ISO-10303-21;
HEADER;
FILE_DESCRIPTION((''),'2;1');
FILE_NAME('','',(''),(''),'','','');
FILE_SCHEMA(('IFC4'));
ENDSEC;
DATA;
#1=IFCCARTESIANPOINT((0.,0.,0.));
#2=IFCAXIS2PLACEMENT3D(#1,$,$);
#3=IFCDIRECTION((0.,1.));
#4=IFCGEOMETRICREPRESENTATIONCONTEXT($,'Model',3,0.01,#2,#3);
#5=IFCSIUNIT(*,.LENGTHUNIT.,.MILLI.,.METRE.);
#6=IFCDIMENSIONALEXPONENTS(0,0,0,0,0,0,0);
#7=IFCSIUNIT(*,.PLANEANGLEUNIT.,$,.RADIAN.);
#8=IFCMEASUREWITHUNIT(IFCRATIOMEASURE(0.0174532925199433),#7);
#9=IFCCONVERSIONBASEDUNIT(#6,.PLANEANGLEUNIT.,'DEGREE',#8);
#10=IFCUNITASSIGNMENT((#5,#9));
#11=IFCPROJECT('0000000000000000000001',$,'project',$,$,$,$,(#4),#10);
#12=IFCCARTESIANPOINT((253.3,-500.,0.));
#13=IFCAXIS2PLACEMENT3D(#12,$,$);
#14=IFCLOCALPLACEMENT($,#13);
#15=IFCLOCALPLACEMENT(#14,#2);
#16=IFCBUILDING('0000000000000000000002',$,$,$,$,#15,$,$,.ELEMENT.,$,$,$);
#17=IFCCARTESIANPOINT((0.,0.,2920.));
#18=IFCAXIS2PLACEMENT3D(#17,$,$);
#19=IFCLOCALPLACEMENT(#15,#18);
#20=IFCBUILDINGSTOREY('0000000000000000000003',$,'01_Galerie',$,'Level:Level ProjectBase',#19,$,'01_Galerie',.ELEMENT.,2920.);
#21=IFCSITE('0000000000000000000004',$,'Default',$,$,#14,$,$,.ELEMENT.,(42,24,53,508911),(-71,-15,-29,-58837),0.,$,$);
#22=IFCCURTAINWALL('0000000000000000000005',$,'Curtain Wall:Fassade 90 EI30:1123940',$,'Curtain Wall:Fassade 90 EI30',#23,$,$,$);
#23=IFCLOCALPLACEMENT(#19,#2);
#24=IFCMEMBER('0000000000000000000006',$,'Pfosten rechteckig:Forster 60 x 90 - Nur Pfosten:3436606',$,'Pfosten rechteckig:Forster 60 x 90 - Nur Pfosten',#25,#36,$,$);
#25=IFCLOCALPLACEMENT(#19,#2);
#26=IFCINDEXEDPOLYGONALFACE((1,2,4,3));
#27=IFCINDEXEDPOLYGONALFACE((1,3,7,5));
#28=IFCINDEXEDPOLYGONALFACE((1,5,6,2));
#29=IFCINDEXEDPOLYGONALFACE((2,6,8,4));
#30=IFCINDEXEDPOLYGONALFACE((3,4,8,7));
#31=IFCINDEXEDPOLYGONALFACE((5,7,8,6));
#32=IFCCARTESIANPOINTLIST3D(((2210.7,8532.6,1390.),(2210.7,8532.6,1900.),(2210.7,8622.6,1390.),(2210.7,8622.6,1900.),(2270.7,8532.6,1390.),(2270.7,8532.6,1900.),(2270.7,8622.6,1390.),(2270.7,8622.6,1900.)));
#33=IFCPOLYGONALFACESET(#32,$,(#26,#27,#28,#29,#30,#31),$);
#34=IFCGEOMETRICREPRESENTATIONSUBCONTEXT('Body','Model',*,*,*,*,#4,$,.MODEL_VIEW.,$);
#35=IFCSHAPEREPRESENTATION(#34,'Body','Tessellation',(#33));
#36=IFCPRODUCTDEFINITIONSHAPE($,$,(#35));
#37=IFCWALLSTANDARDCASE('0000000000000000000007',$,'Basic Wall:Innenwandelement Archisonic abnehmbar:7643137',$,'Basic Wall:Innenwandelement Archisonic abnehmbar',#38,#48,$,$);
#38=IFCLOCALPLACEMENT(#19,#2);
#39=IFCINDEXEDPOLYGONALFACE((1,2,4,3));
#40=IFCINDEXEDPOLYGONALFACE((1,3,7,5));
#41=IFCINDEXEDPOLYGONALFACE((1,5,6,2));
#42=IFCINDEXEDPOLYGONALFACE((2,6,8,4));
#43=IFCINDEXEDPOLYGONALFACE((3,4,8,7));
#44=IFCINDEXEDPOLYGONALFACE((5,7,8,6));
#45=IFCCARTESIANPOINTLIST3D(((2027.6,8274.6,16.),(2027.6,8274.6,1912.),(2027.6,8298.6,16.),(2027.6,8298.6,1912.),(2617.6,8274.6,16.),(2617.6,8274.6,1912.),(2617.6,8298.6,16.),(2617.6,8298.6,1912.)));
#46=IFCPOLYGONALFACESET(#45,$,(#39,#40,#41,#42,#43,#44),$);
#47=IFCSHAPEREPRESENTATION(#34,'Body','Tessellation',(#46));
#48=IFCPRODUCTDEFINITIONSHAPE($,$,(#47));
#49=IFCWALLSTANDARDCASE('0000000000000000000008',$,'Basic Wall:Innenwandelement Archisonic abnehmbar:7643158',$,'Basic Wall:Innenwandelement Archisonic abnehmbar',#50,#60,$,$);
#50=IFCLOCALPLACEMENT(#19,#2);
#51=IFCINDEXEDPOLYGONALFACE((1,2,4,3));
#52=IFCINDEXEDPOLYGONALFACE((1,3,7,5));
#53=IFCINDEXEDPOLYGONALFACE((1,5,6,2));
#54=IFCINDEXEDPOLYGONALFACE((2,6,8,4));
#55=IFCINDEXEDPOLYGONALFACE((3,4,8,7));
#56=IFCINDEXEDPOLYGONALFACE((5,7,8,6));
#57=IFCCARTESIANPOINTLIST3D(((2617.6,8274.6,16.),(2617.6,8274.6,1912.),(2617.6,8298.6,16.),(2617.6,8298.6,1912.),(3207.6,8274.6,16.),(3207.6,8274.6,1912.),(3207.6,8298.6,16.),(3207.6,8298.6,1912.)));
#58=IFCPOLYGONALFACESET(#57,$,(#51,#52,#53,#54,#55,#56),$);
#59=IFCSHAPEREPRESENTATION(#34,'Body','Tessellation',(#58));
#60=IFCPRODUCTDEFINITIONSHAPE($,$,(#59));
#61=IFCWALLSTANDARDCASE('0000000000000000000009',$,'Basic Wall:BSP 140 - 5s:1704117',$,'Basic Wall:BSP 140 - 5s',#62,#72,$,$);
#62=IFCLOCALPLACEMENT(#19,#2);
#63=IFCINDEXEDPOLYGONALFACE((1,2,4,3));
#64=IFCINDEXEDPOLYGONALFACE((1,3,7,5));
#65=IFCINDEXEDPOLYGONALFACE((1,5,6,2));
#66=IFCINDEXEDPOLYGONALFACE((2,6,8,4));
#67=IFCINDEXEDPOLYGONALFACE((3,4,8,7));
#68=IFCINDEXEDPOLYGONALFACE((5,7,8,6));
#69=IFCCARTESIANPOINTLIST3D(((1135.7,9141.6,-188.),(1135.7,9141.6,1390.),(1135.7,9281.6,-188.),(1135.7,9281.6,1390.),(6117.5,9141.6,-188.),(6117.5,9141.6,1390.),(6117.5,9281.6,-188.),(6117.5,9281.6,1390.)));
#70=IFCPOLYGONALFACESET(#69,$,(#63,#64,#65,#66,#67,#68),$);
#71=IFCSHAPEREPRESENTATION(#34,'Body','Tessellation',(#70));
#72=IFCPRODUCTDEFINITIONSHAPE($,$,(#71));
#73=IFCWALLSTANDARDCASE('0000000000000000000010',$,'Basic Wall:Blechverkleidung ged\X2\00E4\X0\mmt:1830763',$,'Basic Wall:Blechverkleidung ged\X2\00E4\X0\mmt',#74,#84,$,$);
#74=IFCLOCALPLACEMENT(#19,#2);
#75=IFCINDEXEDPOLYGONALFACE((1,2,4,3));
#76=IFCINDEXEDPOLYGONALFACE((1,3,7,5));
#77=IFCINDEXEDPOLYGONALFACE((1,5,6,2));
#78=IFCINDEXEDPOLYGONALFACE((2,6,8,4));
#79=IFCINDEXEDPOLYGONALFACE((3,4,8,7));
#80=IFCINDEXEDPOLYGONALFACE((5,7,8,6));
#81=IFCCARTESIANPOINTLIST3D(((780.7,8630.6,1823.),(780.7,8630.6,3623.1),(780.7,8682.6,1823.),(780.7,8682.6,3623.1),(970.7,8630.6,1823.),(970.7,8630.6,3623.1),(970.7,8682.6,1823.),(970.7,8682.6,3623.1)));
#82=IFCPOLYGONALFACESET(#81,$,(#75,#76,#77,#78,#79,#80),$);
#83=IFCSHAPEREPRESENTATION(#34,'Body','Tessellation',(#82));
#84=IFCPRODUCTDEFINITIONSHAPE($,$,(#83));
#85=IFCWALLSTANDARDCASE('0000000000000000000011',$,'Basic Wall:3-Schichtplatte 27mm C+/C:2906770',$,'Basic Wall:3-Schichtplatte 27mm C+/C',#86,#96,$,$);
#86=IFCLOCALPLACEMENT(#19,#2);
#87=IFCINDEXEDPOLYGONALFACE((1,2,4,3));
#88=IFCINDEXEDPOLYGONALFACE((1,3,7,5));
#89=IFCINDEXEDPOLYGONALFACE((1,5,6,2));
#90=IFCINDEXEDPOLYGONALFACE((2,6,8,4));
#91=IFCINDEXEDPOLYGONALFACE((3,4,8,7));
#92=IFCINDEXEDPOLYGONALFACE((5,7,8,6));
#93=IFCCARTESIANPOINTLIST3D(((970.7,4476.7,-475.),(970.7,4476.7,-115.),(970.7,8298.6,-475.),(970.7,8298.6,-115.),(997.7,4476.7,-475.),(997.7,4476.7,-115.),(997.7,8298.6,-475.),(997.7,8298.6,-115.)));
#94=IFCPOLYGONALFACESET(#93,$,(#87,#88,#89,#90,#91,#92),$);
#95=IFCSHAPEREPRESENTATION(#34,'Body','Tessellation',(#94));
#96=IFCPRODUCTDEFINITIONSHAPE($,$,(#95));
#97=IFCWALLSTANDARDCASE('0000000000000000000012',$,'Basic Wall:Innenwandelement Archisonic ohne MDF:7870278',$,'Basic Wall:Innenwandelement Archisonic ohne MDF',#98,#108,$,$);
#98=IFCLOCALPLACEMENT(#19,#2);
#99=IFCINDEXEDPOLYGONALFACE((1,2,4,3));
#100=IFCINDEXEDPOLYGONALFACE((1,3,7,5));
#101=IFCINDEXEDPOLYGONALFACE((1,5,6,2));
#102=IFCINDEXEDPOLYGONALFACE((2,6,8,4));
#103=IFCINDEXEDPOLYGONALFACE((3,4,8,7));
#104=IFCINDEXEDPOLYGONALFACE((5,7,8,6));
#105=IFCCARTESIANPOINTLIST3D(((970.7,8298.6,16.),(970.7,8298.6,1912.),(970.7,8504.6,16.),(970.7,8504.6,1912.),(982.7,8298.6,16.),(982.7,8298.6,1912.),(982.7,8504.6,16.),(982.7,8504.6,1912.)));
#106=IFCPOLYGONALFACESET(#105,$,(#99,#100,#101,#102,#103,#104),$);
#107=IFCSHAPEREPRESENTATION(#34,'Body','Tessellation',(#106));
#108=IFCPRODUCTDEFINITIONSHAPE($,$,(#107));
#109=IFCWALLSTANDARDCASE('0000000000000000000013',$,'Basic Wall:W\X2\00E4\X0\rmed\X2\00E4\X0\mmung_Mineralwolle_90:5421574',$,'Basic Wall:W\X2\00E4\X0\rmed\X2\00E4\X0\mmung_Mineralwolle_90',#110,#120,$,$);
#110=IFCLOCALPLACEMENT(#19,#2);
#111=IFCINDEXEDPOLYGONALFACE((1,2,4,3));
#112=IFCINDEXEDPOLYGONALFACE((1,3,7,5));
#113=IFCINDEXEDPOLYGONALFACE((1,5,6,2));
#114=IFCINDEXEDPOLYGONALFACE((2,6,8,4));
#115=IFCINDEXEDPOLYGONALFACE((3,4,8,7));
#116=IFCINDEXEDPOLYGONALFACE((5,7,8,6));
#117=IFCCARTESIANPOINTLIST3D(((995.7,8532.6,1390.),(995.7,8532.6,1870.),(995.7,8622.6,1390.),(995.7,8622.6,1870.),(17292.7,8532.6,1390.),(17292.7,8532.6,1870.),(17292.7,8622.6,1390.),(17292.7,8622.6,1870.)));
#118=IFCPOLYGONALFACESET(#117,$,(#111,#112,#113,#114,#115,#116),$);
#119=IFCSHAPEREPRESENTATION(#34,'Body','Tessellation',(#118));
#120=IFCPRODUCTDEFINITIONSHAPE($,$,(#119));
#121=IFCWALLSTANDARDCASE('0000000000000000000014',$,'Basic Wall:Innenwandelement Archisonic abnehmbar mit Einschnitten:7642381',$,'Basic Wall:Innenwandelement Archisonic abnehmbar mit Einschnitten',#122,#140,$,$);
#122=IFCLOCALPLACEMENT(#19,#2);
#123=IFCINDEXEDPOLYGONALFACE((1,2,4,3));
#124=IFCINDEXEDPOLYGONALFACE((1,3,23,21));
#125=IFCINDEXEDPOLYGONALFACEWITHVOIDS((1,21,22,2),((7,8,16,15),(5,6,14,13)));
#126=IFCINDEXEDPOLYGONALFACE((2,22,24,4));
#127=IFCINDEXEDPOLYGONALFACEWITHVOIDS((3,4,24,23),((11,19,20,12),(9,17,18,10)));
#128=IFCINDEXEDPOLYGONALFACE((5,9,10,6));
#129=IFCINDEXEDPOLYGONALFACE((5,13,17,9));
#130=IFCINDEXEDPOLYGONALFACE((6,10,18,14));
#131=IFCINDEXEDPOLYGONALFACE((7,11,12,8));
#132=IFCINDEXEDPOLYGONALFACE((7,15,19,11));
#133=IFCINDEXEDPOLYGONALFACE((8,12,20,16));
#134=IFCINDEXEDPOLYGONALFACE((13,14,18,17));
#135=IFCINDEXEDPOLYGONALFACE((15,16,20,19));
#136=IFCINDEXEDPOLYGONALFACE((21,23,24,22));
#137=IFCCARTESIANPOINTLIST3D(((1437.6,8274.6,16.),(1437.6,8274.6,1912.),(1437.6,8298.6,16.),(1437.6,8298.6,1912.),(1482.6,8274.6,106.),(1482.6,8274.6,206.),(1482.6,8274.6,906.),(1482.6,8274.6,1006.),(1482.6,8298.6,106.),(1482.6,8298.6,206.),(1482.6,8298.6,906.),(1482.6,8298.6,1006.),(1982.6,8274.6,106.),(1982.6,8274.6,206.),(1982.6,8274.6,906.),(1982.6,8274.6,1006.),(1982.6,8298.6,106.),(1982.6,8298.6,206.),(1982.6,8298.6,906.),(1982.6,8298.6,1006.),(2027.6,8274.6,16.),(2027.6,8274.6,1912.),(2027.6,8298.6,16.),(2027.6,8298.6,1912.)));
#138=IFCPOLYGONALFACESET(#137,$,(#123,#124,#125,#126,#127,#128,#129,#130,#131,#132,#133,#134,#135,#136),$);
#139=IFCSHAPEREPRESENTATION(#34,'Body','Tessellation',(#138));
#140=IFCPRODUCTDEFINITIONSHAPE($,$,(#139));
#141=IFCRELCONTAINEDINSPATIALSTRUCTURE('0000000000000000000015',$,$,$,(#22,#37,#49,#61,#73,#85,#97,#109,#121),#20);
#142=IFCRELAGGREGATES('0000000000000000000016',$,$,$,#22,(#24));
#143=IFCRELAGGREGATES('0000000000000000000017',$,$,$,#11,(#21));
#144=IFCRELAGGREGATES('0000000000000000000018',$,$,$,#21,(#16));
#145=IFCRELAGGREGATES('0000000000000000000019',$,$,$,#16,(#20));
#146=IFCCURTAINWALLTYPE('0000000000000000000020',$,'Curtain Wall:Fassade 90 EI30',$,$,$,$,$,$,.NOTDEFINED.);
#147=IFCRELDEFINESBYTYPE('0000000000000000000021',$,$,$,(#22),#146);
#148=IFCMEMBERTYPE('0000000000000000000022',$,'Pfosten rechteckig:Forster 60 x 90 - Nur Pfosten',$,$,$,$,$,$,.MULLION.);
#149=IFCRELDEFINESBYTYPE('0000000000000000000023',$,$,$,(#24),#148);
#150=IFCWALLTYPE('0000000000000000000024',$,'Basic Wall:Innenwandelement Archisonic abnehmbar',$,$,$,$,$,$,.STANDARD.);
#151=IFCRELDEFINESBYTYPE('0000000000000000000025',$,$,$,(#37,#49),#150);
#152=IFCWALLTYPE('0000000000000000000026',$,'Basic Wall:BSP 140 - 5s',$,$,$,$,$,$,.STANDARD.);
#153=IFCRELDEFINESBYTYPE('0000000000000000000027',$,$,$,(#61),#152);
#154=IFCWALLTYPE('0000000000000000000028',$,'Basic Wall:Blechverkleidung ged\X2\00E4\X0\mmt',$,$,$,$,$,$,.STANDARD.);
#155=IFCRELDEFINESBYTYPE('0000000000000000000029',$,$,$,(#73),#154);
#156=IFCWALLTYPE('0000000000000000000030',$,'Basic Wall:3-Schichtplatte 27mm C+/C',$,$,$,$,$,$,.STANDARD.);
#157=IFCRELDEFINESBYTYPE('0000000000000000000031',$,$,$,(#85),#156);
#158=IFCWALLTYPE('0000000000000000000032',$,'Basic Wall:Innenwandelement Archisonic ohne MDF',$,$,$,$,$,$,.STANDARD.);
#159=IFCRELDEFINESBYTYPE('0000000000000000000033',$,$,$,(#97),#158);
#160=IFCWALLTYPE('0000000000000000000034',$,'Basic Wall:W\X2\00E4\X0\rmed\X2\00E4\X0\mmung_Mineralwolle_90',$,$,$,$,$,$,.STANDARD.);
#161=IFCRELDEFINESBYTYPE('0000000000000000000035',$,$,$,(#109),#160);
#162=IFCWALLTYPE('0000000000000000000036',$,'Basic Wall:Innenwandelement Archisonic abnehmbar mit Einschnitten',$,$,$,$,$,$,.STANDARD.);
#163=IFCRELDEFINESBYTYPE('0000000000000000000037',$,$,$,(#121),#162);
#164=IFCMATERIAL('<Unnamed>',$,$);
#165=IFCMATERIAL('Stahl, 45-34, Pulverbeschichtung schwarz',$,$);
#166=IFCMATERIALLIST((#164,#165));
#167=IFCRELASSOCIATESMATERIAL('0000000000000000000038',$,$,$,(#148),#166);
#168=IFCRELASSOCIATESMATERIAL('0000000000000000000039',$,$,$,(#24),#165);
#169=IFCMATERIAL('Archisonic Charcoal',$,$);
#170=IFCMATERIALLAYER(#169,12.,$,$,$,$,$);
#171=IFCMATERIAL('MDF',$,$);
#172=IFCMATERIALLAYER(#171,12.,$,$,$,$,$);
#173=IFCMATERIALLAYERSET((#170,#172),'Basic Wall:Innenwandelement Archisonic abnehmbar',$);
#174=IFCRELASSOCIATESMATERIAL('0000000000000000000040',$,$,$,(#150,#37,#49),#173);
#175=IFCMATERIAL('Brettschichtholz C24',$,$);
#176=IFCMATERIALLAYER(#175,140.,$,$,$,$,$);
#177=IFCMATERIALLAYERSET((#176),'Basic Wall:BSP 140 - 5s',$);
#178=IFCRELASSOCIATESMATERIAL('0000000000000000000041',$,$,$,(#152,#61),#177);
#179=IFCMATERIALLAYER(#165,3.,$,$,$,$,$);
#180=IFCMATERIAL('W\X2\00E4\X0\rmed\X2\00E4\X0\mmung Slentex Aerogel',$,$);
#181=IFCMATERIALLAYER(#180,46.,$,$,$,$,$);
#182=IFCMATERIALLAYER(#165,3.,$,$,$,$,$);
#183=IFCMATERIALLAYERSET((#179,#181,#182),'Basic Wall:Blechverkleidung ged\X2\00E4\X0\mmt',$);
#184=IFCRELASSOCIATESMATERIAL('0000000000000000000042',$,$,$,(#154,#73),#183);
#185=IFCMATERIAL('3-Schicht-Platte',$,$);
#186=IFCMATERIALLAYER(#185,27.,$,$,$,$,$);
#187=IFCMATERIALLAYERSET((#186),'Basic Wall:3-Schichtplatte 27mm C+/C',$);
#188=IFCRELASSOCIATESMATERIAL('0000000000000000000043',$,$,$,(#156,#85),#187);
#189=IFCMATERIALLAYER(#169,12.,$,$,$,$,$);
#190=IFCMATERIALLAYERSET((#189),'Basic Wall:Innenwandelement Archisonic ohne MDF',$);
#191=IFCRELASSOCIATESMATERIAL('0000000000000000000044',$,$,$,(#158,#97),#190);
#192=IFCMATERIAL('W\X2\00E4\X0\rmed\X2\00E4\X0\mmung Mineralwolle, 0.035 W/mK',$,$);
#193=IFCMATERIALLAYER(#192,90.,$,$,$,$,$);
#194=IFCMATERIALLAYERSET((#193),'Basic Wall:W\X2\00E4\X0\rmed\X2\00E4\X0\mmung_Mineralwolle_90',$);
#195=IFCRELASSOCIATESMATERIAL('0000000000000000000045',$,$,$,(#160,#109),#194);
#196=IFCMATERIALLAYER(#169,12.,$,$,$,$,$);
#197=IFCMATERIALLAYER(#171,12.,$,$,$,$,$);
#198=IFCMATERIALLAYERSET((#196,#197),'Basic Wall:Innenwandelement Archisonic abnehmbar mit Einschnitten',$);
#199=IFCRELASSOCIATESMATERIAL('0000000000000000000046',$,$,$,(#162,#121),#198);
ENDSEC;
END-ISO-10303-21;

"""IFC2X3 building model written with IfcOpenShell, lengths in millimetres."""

from ifc_helpers import new_model, entity, si_unit, converted_unit, direction, frame, frame_2d, origin, origin_2d_with_axis, place, context, subcontext, project, spatial, rectangle, extrude, source, transform, mapped, material, material_list, layer, layer_set, layer_usage, type_object, type_shapes, element, aggregate, save


model = new_model("IFC2X3")

# Units and contexts
model_context = context("Model", 3, precision=0.01, world=origin(), true_north=direction((0.0, 1.0)))
body_context = subcontext(model_context, "Body", "Model", "MODEL_VIEW")
ifc_project = project(units=[si_unit("LENGTHUNIT", "METRE", prefix="MILLI"), converted_unit("PLANEANGLEUNIT", "DEGREE", entity("IfcRatioMeasure", 0.0174532925199433), si_unit("PLANEANGLEUNIT", "RADIAN"), dimensions=[0, 0, 0, 0, 0, 0, 0])], contexts=[model_context])

# Site, building, storey
site_placement = place(None, frame((253.3, -500.0, 0.0)))
site = spatial("IfcSite", under=ifc_project, at=site_placement, Name="Default", CompositionType="ELEMENT", RefLatitude=(42, 24, 53, 508911), RefLongitude=(-71, -15, -29, -58837), RefElevation=0.0)
building_placement = place(site_placement, origin())
building = spatial("IfcBuilding", under=site, at=building_placement, CompositionType="ELEMENT")
storey_placement = place(building_placement, frame((0.0, 0.0, 2920.0)))
storey = spatial("IfcBuildingStorey", under=building, at=storey_placement, Name="01_Galerie", ObjectType="Level:Level ProjectBase", LongName="01_Galerie", CompositionType="ELEMENT", Elevation=2920.0)

# Curtain wall, member
curtain_wall_type = type_object("IfcCurtainWallType", Name="Curtain Wall:Fassade 90 EI30", PredefinedType="NOTDEFINED")
curtain_wall_placement = place(storey_placement, frame((0.0, 0.0, -2920.0)))
curtain_wall = element("IfcCurtainWall", 1, at=curtain_wall_placement, inside=storey, type_object=curtain_wall_type, Name="Curtain Wall:Fassade 90 EI30:1123940", ObjectType="Curtain Wall:Fassade 90 EI30")
ifc_material_1 = material(Name="Stahl, 45-34, Pulverbeschichtung schwarz")
ifc_material_2 = material(Name="<Unnamed>")
ifc_material_list_1 = material_list([ifc_material_2, ifc_material_1])
member_type_1 = type_object("IfcMemberType", Name="Pfosten rechteckig:Forster 60 x 90 - Nur Pfosten", PredefinedType="MULLION", material=ifc_material_list_1)
shared_shape_1 = source(origin(), body_context, "Body", "SweptSolid", [
    extrude(rectangle(XDim=90.0, YDim=60.0, at=origin_2d_with_axis()), frame((0.0, 79.0, -510.0), z_axis=(0.0, 0.0, 1.0), x_axis=(0.0, -1.0, 0.0)), (0.0, 0.0, 1.0), 510.0),
])
type_shapes(member_type_1, [shared_shape_1])
member_1_placement = place(storey_placement, frame((2240.7, 8656.6, 1390.0), z_axis=(0.0, 0.0, -1.0), x_axis=(1.0, 0.0, 0.0)))
member_1 = element("IfcMember", 2, at=member_1_placement, type_object=member_type_1, material=ifc_material_1, Name="Pfosten rechteckig:Forster 60 x 90 - Nur Pfosten:3436606", ObjectType="Pfosten rechteckig:Forster 60 x 90 - Nur Pfosten", context=body_context, shape_type="MappedRepresentation", body=[
    mapped(shared_shape_1, transform((0.0, 0.0, 0.0), scale=1.0)),
])
aggregate(curtain_wall, [member_1])

# Walls
ifc_material_3 = material(Name="Archisonic Charcoal")
ifc_layer_1 = layer(ifc_material_3, 12.0)
ifc_material_4 = material(Name="MDF")
ifc_layer_2 = layer(ifc_material_4, 12.0)
ifc_layer_set_1 = layer_set([ifc_layer_1, ifc_layer_2], Name="Basic Wall:Innenwandelement Archisonic abnehmbar")
ifc_layer_usage_1 = layer_usage(ifc_layer_set_1, "AXIS2", "NEGATIVE", 12.0)
wall_type_1 = type_object("IfcWallType", Name="Basic Wall:Innenwandelement Archisonic abnehmbar", PredefinedType="STANDARD", material=ifc_layer_set_1)
wall_1_placement = place(storey_placement, frame((2617.6, 8286.6, 16.0), z_axis=(0.0, 0.0, 1.0), x_axis=(-1.0, 0.0, 0.0)))
element("IfcWallStandardCase", 3, at=wall_1_placement, inside=storey, type_object=wall_type_1, material=ifc_layer_usage_1, Name="Basic Wall:Innenwandelement Archisonic abnehmbar:7643137", ObjectType="Basic Wall:Innenwandelement Archisonic abnehmbar", context=body_context, shape_type="SweptSolid", body=[
    extrude(rectangle(XDim=590.0, YDim=24.0, at=frame_2d((295.0, 0.0), x_axis=(-1.0, 0.0))), origin(), (0.0, 0.0, 1.0), 1896.0),
])
ifc_layer_usage_2 = layer_usage(ifc_layer_set_1, "AXIS2", "NEGATIVE", 12.0)
wall_2_placement = place(storey_placement, frame((3207.6, 8286.6, 16.0), z_axis=(0.0, 0.0, 1.0), x_axis=(-1.0, 0.0, 0.0)))
element("IfcWallStandardCase", 4, at=wall_2_placement, inside=storey, type_object=wall_type_1, material=ifc_layer_usage_2, Name="Basic Wall:Innenwandelement Archisonic abnehmbar:7643158", ObjectType="Basic Wall:Innenwandelement Archisonic abnehmbar", context=body_context, shape_type="SweptSolid", body=[
    extrude(rectangle(XDim=590.0, YDim=24.0, at=frame_2d((295.0, 0.0), x_axis=(-1.0, 0.0))), origin(), (0.0, 0.0, 1.0), 1896.0),
])
ifc_material_5 = material(Name="Brettschichtholz C24")
ifc_layer_3 = layer(ifc_material_5, 140.0)
ifc_layer_set_2 = layer_set([ifc_layer_3], Name="Basic Wall:BSP 140 - 5s")
ifc_layer_usage_3 = layer_usage(ifc_layer_set_2, "AXIS2", "NEGATIVE", 70.0)
wall_type_2 = type_object("IfcWallType", Name="Basic Wall:BSP 140 - 5s", PredefinedType="STANDARD", material=ifc_layer_set_2)
wall_3_placement = place(storey_placement, frame((1135.7, 9211.6, -188.0)))
element("IfcWallStandardCase", 5, at=wall_3_placement, inside=storey, type_object=wall_type_2, material=ifc_layer_usage_3, Name="Basic Wall:BSP 140 - 5s:1704117", ObjectType="Basic Wall:BSP 140 - 5s", context=body_context, shape_type="SweptSolid", body=[
    extrude(rectangle(XDim=4981.8, YDim=140.0, at=frame_2d((2490.9, 0.0), x_axis=(-1.0, 0.0))), origin(), (0.0, 0.0, 1.0), 1578.0),
])

# Walls
ifc_layer_4 = layer(ifc_material_1, 3.0)
ifc_material_6 = material(Name="Wärmedämmung Slentex Aerogel")
ifc_layer_5 = layer(ifc_material_6, 46.0)
ifc_layer_6 = layer(ifc_material_1, 3.0)
ifc_layer_set_3 = layer_set([ifc_layer_4, ifc_layer_5, ifc_layer_6], Name="Basic Wall:Blechverkleidung gedämmt")
ifc_layer_usage_4 = layer_usage(ifc_layer_set_3, "AXIS2", "NEGATIVE", 26.0)
wall_type_3 = type_object("IfcWallType", Name="Basic Wall:Blechverkleidung gedämmt", PredefinedType="STANDARD", material=ifc_layer_set_3)
wall_4_placement = place(storey_placement, frame((970.7, 8656.6, 1823.0), z_axis=(0.0, 0.0, 1.0), x_axis=(-1.0, 0.0, 0.0)))
element("IfcWallStandardCase", 6, at=wall_4_placement, inside=storey, type_object=wall_type_3, material=ifc_layer_usage_4, Name="Basic Wall:Blechverkleidung gedämmt:1830763", ObjectType="Basic Wall:Blechverkleidung gedämmt", context=body_context, shape_type="SweptSolid", body=[
    extrude(rectangle(XDim=190.0, YDim=52.0, at=frame_2d((95.0, 0.0), x_axis=(-1.0, 0.0))), origin(), (0.0, 0.0, 1.0), 1800.1),
])
ifc_material_7 = material(Name="3-Schicht-Platte")
ifc_layer_7 = layer(ifc_material_7, 27.0)
ifc_layer_set_4 = layer_set([ifc_layer_7], Name="Basic Wall:3-Schichtplatte 27mm C+/C")
ifc_layer_usage_5 = layer_usage(ifc_layer_set_4, "AXIS2", "POSITIVE", -13.5)
wall_type_4 = type_object("IfcWallType", Name="Basic Wall:3-Schichtplatte 27mm C+/C", PredefinedType="STANDARD", material=ifc_layer_set_4)
wall_5_placement = place(storey_placement, frame((984.2, 8298.6, -475.0), z_axis=(0.0, 0.0, 1.0), x_axis=(0.0, -1.0, 0.0)))
element("IfcWallStandardCase", 7, at=wall_5_placement, inside=storey, type_object=wall_type_4, material=ifc_layer_usage_5, Name="Basic Wall:3-Schichtplatte 27mm C+/C:2906770", ObjectType="Basic Wall:3-Schichtplatte 27mm C+/C", context=body_context, shape_type="SweptSolid", body=[
    extrude(rectangle(XDim=3821.9, YDim=27.0, at=frame_2d((1911.0, 0.0), x_axis=(-1.0, 0.0))), origin(), (0.0, 0.0, 1.0), 360.0),
])
ifc_layer_8 = layer(ifc_material_3, 12.0)
ifc_layer_set_5 = layer_set([ifc_layer_8], Name="Basic Wall:Innenwandelement Archisonic ohne MDF")
ifc_layer_usage_6 = layer_usage(ifc_layer_set_5, "AXIS2", "NEGATIVE", 6.0)
wall_type_5 = type_object("IfcWallType", Name="Basic Wall:Innenwandelement Archisonic ohne MDF", PredefinedType="STANDARD", material=ifc_layer_set_5)
wall_6_placement = place(storey_placement, frame((976.7, 8298.6, 16.0), z_axis=(0.0, 0.0, 1.0), x_axis=(0.0, 1.0, 0.0)))
element("IfcWallStandardCase", 8, at=wall_6_placement, inside=storey, type_object=wall_type_5, material=ifc_layer_usage_6, Name="Basic Wall:Innenwandelement Archisonic ohne MDF:7870278", ObjectType="Basic Wall:Innenwandelement Archisonic ohne MDF", context=body_context, shape_type="SweptSolid", body=[
    extrude(rectangle(XDim=206.0, YDim=12.0, at=frame_2d((103.0, 0.0), x_axis=(-1.0, 0.0))), origin(), (0.0, 0.0, 1.0), 1896.0),
])
ifc_material_8 = material(Name="Wärmedämmung Mineralwolle, 0.035 W/mK")
ifc_layer_9 = layer(ifc_material_8, 90.0)
ifc_layer_set_6 = layer_set([ifc_layer_9], Name="Basic Wall:Wärmedämmung_Mineralwolle_90")
ifc_layer_usage_7 = layer_usage(ifc_layer_set_6, "AXIS2", "POSITIVE", -45.0)
wall_type_6 = type_object("IfcWallType", Name="Basic Wall:Wärmedämmung_Mineralwolle_90", PredefinedType="STANDARD", material=ifc_layer_set_6)
wall_7_placement = place(storey_placement, frame((995.7, 8577.6, 1390.0)))
element("IfcWallStandardCase", 9, at=wall_7_placement, inside=storey, type_object=wall_type_6, material=ifc_layer_usage_7, Name="Basic Wall:Wärmedämmung_Mineralwolle_90:5421574", ObjectType="Basic Wall:Wärmedämmung_Mineralwolle_90", context=body_context, shape_type="SweptSolid", body=[
    extrude(rectangle(XDim=16297.0, YDim=90.0, at=frame_2d((8148.5, 0.0), x_axis=(-1.0, 0.0))), origin(), (0.0, 0.0, 1.0), 480.0),
])

# Wall, openings
ifc_layer_10 = layer(ifc_material_3, 12.0)
ifc_layer_11 = layer(ifc_material_4, 12.0)
ifc_layer_set_7 = layer_set([ifc_layer_10, ifc_layer_11], Name="Basic Wall:Innenwandelement Archisonic abnehmbar mit Einschnitten")
ifc_layer_usage_8 = layer_usage(ifc_layer_set_7, "AXIS2", "NEGATIVE", 12.0)
wall_type_7 = type_object("IfcWallType", Name="Basic Wall:Innenwandelement Archisonic abnehmbar mit Einschnitten", PredefinedType="STANDARD", material=ifc_layer_set_7)
wall_8_placement = place(storey_placement, frame((2027.6, 8286.6, 16.0), z_axis=(0.0, 0.0, 1.0), x_axis=(-1.0, 0.0, 0.0)))
wall_8 = element("IfcWallStandardCase", 10, at=wall_8_placement, inside=storey, type_object=wall_type_7, material=ifc_layer_usage_8, Name="Basic Wall:Innenwandelement Archisonic abnehmbar mit Einschnitten:7642381", ObjectType="Basic Wall:Innenwandelement Archisonic abnehmbar mit Einschnitten", context=body_context, shape_type="SweptSolid", body=[
    extrude(rectangle(XDim=590.0, YDim=24.0, at=frame_2d((295.0, 0.0), x_axis=(-1.0, 0.0))), origin(), (0.0, 0.0, 1.0), 1896.0),
])
opening_1_placement = place(wall_8_placement, frame((545.0, 61.6, 890.0)))
element("IfcOpeningElement", 11, at=opening_1_placement, cuts=wall_8, ObjectType="Opening", context=body_context, shape_type="SweptSolid", body=[
    extrude(rectangle(XDim=100.0, YDim=500.0, at=frame_2d((0.0, 0.0), x_axis=(1.0, 0.0))), frame((-250.0, -530.4, 50.0), z_axis=(0.0, 1.0, 0.0), x_axis=(0.0, 0.0, 1.0)), (0.0, 0.0, 1.0), 530.4),
])
opening_2_placement = place(wall_8_placement, frame((545.0, 61.6, 90.0)))
element("IfcOpeningElement", 12, at=opening_2_placement, cuts=wall_8, ObjectType="Opening", context=body_context, shape_type="SweptSolid", body=[
    extrude(rectangle(XDim=100.0, YDim=500.0, at=origin_2d_with_axis()), frame((-250.0, -480.4, 50.0), z_axis=(0.0, 1.0, 0.0), x_axis=(0.0, 0.0, 1.0)), (0.0, 0.0, 1.0), 480.4),
])

save(model, "model.ifc")
